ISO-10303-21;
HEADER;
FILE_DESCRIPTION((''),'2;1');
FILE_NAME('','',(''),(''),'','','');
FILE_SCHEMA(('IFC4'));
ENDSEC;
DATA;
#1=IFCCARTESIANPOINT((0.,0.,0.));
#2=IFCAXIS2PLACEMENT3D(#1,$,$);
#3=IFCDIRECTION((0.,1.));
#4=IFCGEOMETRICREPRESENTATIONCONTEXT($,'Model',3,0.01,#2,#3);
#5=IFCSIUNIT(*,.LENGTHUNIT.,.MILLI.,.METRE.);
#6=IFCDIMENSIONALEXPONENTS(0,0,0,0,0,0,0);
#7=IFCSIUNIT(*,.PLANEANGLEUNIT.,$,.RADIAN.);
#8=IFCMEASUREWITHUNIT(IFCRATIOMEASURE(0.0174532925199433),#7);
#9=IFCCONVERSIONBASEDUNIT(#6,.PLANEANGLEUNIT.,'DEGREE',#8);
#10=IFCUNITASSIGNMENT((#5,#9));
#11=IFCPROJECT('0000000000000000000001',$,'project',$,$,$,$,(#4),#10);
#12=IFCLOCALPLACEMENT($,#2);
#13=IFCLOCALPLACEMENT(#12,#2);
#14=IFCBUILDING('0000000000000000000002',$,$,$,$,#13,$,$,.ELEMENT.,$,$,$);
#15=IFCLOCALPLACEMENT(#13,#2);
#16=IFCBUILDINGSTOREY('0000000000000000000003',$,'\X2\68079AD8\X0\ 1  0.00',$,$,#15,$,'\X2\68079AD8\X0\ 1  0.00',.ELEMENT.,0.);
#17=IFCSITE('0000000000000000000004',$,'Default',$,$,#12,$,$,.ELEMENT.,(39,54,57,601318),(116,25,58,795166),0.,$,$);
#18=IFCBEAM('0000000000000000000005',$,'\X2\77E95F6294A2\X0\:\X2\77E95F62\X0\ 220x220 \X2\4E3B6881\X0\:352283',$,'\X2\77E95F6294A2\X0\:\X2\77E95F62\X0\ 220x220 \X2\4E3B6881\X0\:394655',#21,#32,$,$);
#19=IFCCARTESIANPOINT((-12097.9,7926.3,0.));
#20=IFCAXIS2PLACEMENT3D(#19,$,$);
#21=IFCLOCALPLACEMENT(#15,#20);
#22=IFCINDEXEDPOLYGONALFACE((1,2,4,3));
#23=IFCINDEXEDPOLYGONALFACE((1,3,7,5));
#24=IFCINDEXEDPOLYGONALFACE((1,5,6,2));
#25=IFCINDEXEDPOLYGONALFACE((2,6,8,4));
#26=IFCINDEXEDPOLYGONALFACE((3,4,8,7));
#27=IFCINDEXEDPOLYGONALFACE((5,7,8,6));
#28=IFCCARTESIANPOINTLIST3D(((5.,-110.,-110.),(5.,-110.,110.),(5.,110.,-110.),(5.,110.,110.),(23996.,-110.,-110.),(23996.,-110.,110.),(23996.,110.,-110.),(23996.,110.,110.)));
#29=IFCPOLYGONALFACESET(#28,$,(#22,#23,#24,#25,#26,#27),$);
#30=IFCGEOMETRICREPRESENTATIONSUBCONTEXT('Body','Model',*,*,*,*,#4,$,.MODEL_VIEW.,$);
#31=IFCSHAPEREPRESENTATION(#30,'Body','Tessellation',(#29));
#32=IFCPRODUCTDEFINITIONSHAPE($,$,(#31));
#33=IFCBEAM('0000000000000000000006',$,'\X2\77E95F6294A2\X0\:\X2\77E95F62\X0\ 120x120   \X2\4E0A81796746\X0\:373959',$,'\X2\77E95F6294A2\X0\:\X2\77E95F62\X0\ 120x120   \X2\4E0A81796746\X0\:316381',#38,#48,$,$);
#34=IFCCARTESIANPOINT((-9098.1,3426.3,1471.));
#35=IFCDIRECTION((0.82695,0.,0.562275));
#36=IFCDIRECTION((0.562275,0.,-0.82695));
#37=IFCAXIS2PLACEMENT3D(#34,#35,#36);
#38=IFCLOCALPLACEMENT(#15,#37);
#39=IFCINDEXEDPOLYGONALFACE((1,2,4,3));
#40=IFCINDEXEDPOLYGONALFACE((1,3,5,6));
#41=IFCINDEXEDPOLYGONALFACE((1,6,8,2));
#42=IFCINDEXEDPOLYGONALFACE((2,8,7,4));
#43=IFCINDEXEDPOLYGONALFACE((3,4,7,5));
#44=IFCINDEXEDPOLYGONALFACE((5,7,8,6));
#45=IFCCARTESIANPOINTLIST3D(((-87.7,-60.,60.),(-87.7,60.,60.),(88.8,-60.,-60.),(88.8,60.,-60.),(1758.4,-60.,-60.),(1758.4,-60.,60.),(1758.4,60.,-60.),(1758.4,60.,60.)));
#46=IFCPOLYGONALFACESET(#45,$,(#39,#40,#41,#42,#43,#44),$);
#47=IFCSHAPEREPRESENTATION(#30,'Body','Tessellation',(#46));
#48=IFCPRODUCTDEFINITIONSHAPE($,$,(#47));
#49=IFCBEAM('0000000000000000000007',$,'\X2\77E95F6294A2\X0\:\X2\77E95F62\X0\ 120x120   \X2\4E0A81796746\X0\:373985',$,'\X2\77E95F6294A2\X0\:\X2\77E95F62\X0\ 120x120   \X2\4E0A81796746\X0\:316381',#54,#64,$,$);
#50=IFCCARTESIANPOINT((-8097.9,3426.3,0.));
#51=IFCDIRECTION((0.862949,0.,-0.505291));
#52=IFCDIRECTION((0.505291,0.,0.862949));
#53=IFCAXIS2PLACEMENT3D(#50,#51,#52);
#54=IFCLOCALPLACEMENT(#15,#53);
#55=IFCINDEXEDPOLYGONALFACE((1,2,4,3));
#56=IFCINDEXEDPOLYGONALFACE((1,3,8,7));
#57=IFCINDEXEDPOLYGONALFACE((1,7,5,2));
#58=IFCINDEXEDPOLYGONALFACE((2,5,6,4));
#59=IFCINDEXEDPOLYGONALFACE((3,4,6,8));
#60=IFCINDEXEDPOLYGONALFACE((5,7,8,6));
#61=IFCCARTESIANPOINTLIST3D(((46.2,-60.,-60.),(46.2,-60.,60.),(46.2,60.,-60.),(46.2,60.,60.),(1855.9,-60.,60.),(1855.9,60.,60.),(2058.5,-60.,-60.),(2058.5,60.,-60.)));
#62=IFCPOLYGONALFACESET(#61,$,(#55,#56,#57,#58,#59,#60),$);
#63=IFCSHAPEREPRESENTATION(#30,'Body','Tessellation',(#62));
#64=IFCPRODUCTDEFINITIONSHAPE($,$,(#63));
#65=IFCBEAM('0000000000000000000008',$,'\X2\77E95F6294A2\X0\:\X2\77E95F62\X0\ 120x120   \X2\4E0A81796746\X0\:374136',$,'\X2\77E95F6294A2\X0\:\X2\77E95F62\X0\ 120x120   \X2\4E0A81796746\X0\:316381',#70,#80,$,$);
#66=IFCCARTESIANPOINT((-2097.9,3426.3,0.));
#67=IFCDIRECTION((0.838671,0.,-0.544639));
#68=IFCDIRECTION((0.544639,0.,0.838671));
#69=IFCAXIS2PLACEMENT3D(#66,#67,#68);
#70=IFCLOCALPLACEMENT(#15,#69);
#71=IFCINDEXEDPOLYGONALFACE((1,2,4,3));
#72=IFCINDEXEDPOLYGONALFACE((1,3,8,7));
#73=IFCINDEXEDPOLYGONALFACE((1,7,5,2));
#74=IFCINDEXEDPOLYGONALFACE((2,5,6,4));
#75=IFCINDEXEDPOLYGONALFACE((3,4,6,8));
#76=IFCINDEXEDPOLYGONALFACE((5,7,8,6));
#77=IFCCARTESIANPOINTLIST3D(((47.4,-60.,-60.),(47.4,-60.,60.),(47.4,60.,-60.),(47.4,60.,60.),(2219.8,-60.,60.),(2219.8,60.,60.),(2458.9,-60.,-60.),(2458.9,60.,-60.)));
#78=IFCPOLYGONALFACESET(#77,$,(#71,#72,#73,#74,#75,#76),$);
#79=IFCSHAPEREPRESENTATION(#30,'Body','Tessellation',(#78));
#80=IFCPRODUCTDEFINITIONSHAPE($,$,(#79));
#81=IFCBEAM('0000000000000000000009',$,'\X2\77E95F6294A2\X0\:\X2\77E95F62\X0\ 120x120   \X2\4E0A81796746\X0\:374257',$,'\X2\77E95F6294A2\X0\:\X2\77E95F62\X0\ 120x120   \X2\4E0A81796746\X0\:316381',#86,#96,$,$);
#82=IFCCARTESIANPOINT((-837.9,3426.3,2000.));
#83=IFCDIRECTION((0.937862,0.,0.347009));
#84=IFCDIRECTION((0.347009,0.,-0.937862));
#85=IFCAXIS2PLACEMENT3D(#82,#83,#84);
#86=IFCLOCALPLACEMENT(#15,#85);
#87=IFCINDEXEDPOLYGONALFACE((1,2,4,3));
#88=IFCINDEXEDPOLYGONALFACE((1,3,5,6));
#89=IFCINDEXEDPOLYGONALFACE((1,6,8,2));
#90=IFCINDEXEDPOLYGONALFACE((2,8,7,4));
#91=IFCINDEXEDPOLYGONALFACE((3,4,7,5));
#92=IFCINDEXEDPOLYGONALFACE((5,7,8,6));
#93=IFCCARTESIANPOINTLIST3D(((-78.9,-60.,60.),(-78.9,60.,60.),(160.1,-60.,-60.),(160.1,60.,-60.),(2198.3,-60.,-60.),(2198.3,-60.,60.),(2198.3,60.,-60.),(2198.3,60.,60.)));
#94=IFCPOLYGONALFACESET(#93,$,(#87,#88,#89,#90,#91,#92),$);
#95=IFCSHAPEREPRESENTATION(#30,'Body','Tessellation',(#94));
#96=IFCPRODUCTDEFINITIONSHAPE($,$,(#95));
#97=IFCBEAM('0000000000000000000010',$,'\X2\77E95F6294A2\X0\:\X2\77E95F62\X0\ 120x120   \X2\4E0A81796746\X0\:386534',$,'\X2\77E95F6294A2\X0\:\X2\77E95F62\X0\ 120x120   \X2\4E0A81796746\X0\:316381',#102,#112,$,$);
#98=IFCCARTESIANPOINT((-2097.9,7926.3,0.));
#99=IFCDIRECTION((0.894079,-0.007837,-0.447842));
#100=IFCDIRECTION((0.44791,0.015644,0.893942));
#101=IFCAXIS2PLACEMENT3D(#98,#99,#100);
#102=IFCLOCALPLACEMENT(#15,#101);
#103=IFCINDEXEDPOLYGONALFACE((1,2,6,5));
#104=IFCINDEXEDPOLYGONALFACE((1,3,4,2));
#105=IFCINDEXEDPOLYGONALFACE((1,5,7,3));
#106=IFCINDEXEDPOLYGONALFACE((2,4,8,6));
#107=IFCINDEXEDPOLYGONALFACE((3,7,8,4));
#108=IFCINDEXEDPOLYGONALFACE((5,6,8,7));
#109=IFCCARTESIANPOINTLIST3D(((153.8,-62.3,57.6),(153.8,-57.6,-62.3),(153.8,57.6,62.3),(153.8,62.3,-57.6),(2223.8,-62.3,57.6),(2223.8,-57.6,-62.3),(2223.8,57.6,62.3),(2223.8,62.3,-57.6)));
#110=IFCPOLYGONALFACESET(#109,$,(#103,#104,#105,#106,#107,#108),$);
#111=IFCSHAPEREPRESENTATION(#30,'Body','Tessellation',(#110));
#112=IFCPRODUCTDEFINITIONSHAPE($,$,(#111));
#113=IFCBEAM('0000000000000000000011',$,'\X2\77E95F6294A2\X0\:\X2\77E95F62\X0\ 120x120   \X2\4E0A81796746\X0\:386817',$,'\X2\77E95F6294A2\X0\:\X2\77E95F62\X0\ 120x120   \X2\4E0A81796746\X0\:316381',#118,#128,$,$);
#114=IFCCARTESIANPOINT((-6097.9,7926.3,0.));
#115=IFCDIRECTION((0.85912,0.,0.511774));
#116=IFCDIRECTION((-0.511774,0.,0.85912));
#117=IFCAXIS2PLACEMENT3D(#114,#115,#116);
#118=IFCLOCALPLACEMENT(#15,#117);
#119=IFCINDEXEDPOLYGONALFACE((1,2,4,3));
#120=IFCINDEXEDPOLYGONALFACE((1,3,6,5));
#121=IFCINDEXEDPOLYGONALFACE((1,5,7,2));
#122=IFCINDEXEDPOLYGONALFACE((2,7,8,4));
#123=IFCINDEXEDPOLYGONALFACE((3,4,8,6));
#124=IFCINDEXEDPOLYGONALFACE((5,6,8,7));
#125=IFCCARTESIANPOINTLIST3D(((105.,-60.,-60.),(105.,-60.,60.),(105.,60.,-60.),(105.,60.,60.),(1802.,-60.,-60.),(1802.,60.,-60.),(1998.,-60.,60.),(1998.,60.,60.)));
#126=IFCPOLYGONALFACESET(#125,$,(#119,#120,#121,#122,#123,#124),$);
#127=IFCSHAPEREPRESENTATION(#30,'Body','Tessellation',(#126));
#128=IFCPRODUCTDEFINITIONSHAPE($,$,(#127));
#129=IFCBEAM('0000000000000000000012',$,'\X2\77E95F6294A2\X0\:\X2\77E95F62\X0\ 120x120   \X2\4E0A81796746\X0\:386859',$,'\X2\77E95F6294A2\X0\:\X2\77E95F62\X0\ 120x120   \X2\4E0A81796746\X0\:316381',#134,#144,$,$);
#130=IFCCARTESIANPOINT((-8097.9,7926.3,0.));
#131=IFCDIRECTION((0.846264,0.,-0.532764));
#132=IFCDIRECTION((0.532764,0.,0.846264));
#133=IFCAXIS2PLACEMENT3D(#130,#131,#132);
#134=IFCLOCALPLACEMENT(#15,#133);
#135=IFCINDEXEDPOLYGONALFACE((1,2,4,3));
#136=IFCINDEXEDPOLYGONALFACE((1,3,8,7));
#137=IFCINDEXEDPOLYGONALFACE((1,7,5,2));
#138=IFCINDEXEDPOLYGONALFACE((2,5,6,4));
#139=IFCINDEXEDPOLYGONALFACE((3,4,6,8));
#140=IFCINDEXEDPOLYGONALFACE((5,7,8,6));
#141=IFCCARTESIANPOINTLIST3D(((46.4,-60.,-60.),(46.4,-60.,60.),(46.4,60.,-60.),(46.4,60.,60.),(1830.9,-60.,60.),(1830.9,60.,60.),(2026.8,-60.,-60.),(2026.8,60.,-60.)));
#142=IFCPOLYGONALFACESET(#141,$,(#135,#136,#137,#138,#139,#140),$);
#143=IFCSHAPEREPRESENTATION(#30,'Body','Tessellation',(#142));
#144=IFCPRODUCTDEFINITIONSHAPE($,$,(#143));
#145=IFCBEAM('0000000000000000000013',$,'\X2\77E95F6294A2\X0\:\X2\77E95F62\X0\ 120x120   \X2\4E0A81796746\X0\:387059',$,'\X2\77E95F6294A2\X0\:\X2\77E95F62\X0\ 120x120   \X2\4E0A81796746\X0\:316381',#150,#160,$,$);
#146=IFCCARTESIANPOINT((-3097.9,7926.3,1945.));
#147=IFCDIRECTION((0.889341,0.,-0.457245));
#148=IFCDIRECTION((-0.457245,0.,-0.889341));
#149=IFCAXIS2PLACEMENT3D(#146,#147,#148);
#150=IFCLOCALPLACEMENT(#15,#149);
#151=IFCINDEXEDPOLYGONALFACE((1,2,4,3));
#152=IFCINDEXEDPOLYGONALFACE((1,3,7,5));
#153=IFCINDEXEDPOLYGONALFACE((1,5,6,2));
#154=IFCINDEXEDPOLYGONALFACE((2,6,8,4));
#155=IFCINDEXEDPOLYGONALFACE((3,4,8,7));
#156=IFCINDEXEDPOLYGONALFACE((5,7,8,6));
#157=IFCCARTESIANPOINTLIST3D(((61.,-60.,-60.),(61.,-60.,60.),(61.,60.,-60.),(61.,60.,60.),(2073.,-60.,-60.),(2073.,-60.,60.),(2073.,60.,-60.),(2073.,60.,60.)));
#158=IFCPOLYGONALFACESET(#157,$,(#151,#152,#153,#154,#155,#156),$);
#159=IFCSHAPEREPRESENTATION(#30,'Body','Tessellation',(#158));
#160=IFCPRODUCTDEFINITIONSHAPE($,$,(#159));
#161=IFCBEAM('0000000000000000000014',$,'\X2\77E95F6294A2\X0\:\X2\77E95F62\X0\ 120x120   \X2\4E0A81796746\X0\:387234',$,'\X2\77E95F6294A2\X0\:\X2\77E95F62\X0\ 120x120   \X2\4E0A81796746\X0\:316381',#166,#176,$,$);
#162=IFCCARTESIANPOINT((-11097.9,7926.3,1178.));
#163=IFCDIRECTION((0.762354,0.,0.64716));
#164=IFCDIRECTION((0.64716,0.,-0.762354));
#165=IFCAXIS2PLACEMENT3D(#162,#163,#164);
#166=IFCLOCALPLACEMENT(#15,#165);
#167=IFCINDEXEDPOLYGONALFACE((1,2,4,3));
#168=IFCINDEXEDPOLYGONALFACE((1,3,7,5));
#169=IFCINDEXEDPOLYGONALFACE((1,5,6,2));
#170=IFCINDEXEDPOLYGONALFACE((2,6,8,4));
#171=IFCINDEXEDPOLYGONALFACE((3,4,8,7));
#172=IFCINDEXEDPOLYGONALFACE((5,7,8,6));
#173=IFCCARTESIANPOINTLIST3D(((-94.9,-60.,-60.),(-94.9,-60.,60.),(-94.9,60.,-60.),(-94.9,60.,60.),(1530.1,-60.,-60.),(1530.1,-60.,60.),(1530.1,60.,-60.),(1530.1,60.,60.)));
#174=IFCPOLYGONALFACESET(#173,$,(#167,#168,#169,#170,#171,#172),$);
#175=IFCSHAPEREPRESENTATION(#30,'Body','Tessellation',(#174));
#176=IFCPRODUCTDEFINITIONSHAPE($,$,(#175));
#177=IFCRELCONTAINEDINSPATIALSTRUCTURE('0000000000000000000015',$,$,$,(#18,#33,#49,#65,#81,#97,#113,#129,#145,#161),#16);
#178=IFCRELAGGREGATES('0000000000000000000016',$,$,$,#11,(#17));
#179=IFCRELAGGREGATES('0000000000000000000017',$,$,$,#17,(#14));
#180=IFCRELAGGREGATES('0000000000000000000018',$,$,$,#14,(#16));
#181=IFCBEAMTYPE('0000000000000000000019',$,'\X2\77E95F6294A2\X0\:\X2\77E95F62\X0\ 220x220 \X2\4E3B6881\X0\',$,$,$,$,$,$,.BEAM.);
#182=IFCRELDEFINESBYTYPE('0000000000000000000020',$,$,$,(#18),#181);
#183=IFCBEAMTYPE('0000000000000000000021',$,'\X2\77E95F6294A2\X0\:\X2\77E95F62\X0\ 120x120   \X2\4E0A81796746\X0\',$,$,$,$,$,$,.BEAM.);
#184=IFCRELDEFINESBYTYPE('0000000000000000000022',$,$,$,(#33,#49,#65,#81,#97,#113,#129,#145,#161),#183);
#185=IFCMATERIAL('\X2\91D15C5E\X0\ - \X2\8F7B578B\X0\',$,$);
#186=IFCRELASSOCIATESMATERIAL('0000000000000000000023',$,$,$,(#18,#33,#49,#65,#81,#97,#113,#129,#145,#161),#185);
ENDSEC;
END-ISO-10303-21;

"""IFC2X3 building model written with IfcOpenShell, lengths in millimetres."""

from ifc_helpers import new_model, entity, si_unit, converted_unit, direction, frame, frame_2d, origin, place, context, subcontext, project, spatial, rectangle, extrude, clip, halfspace, material, type_object, element, save


model = new_model("IFC2X3")

# Units and contexts
model_context = context("Model", 3, precision=0.01, world=origin(), true_north=direction((0.0, 1.0)))
body_context = subcontext(model_context, "Body", "Model", "MODEL_VIEW")
ifc_project = project(units=[si_unit("LENGTHUNIT", "METRE", prefix="MILLI"), converted_unit("PLANEANGLEUNIT", "DEGREE", entity("IfcRatioMeasure", 0.0174532925199433), si_unit("PLANEANGLEUNIT", "RADIAN"), dimensions=[0, 0, 0, 0, 0, 0, 0])], contexts=[model_context])

# Site, building, storey
site_placement = place(None, origin())
site = spatial("IfcSite", under=ifc_project, at=site_placement, Name="Default", CompositionType="ELEMENT", RefLatitude=(39, 54, 57, 601318), RefLongitude=(116, 25, 58, 795166), RefElevation=0.0)
building_placement = place(site_placement, origin())
building = spatial("IfcBuilding", under=site, at=building_placement, CompositionType="ELEMENT")
storey_placement = place(building_placement, origin())
storey = spatial("IfcBuildingStorey", under=building, at=storey_placement, Name="标高 1  0.00", LongName="标高 1  0.00", CompositionType="ELEMENT", Elevation=0.0)

# Shared definitions
ifc_material_1 = material(Name="金属 - 轻型")

# Beams
beam_type_1 = type_object("IfcBeamType", Name="矩形钢:矩形 220x220 主梁", PredefinedType="BEAM")
beam_1_placement = place(storey_placement, frame((-12097.9, 7926.3, 0.0)))
element("IfcBeam", 1, at=beam_1_placement, inside=storey, type_object=beam_type_1, material=ifc_material_1, Name="矩形钢:矩形 220x220 主梁:352283", ObjectType="矩形钢:矩形 220x220 主梁:394655", context=body_context, shape_type="SweptSolid", body=[
    extrude(rectangle(XDim=220.0, YDim=220.0, at=frame_2d((0.0, 0.0), x_axis=(1.0, 0.0))), frame((5.0, 0.0, 0.0), z_axis=(1.0, 0.0, 0.0), x_axis=(0.0, 0.0, -1.0)), (0.0, 0.0, 1.0), 23991.0),
])
beam_type_2 = type_object("IfcBeamType", Name="矩形钢:矩形 120x120   上腹杆", PredefinedType="BEAM")
beam_2_placement = place(storey_placement, frame((-9098.1, 3426.3, 1471.0), z_axis=(0.82695, 0.0, 0.562275), x_axis=(0.562275, 0.0, -0.82695)))
element("IfcBeam", 2, at=beam_2_placement, inside=storey, type_object=beam_type_2, material=ifc_material_1, Name="矩形钢:矩形 120x120   上腹杆:373959", ObjectType="矩形钢:矩形 120x120   上腹杆:316381", context=body_context, shape_type="Clipping", body=[
    clip(extrude(rectangle(XDim=120.0, YDim=120.0, at=frame_2d((0.0, 0.0), x_axis=(1.0, 0.0))), frame((-87.7, 0.0, 0.0), z_axis=(1.0, 0.0, 0.0), x_axis=(0.0, 0.0, -1.0)), (0.0, 0.0, 1.0), 1846.1), halfspace(frame((-87.7, 0.0, 60.0), z_axis=(-0.562323, 0.0, -0.826918), x_axis=(0.0, 1.0, 0.0)), False)),
])
beam_3_placement = place(storey_placement, frame((-8097.9, 3426.3, 0.0), z_axis=(0.862949, 0.0, -0.505291), x_axis=(0.505291, 0.0, 0.862949)))
element("IfcBeam", 3, at=beam_3_placement, inside=storey, type_object=beam_type_2, material=ifc_material_1, Name="矩形钢:矩形 120x120   上腹杆:373985", ObjectType="矩形钢:矩形 120x120   上腹杆:316381", context=body_context, shape_type="Clipping", body=[
    clip(extrude(rectangle(XDim=120.0, YDim=120.0, at=frame_2d((0.0, 0.0), x_axis=(1.0, 0.0))), frame((46.2, 0.0, 0.0), z_axis=(1.0, 0.0, 0.0), x_axis=(0.0, 0.0, -1.0)), (0.0, 0.0, 1.0), 2012.3), halfspace(frame((2058.5, 0.0, -60.0), z_axis=(0.509462, 0.0, 0.860493), x_axis=(-0.860493, 0.0, 0.509462)), False)),
])
beam_4_placement = place(storey_placement, frame((-2097.9, 3426.3, 0.0), z_axis=(0.838671, 0.0, -0.544639), x_axis=(0.544639, 0.0, 0.838671)))
element("IfcBeam", 4, at=beam_4_placement, inside=storey, type_object=beam_type_2, material=ifc_material_1, Name="矩形钢:矩形 120x120   上腹杆:374136", ObjectType="矩形钢:矩形 120x120   上腹杆:316381", context=body_context, shape_type="Clipping", body=[
    clip(extrude(rectangle(XDim=120.0, YDim=120.0, at=frame_2d((0.0, 0.0), x_axis=(1.0, 0.0))), frame((47.4, 0.0, 0.0), z_axis=(1.0, 0.0, 0.0), x_axis=(0.0, 0.0, -1.0)), (0.0, 0.0, 1.0), 2411.5), halfspace(frame((2458.9, 0.0, -60.0), z_axis=(0.448574, 0.0, 0.893746), x_axis=(0.893746, 0.0, -0.448574)), False)),
])
beam_5_placement = place(storey_placement, frame((-837.9, 3426.3, 2000.0), z_axis=(0.937862, 0.0, 0.347009), x_axis=(0.347009, 0.0, -0.937862)))
element("IfcBeam", 5, at=beam_5_placement, inside=storey, type_object=beam_type_2, material=ifc_material_1, Name="矩形钢:矩形 120x120   上腹杆:374257", ObjectType="矩形钢:矩形 120x120   上腹杆:316381", context=body_context, shape_type="Clipping", body=[
    clip(extrude(rectangle(XDim=120.0, YDim=120.0, at=frame_2d((0.0, 0.0), x_axis=(1.0, 0.0))), frame((-78.9, 0.0, 0.0), z_axis=(1.0, 0.0, 0.0), x_axis=(0.0, 0.0, -1.0)), (0.0, 0.0, 1.0), 2277.2), halfspace(frame((-78.9, 0.0, 60.0), z_axis=(-0.448574, 0.0, -0.893746), x_axis=(-0.893746, 0.0, 0.448574)), False)),
])
beam_6_placement = place(storey_placement, frame((-2097.9, 7926.3, 0.0), z_axis=(0.894079, -0.007837, -0.447842), x_axis=(0.44791, 0.015644, 0.893942)))
element("IfcBeam", 6, at=beam_6_placement, inside=storey, type_object=beam_type_2, material=ifc_material_1, Name="矩形钢:矩形 120x120   上腹杆:386534", ObjectType="矩形钢:矩形 120x120   上腹杆:316381", context=body_context, shape_type="SweptSolid", body=[
    extrude(rectangle(XDim=120.0, YDim=120.0, at=frame_2d((0.0, 0.0), x_axis=(1.0, 0.0))), frame((153.8, 0.0, 0.0), z_axis=(1.0, 0.0, 0.0), x_axis=(0.0, -0.03904, 0.999238)), (0.0, 0.0, 1.0), 2070.0),
])
beam_7_placement = place(storey_placement, frame((-6097.9, 7926.3, 0.0), z_axis=(0.85912, 0.0, 0.511774), x_axis=(-0.511774, 0.0, 0.85912)))
element("IfcBeam", 7, at=beam_7_placement, inside=storey, type_object=beam_type_2, material=ifc_material_1, Name="矩形钢:矩形 120x120   上腹杆:386817", ObjectType="矩形钢:矩形 120x120   上腹杆:316381", context=body_context, shape_type="Clipping", body=[
    clip(extrude(rectangle(XDim=120.0, YDim=120.0, at=frame_2d((0.0, 0.0), x_axis=(1.0, 0.0))), frame((105.0, 0.0, 0.0), z_axis=(1.0, 0.0, 0.0), x_axis=(0.0, 0.0, -1.0)), (0.0, 0.0, 1.0), 1893.0), halfspace(frame((1802.0, 0.0, -60.0), z_axis=(0.522309, 0.0, -0.852757), x_axis=(0.852757, 0.0, 0.522309)), False)),
])
beam_8_placement = place(storey_placement, frame((-8097.9, 7926.3, 0.0), z_axis=(0.846264, 0.0, -0.532764), x_axis=(0.532764, 0.0, 0.846264)))
element("IfcBeam", 8, at=beam_8_placement, inside=storey, type_object=beam_type_2, material=ifc_material_1, Name="矩形钢:矩形 120x120   上腹杆:386859", ObjectType="矩形钢:矩形 120x120   上腹杆:316381", context=body_context, shape_type="Clipping", body=[
    clip(extrude(rectangle(XDim=120.0, YDim=120.0, at=frame_2d((0.0, 0.0), x_axis=(1.0, 0.0))), frame((46.4, 0.0, 0.0), z_axis=(1.0, 0.0, 0.0), x_axis=(0.0, 0.0, -1.0)), (0.0, 0.0, 1.0), 1980.4), halfspace(frame((1830.9, 0.0, 60.0), z_axis=(0.522309, 0.0, 0.852757), x_axis=(0.852757, 0.0, -0.522309)), False)),
])
beam_9_placement = place(storey_placement, frame((-3097.9, 7926.3, 1945.0), z_axis=(0.889341, 0.0, -0.457245), x_axis=(-0.457245, 0.0, -0.889341)))
element("IfcBeam", 9, at=beam_9_placement, inside=storey, type_object=beam_type_2, material=ifc_material_1, Name="矩形钢:矩形 120x120   上腹杆:387059", ObjectType="矩形钢:矩形 120x120   上腹杆:316381", context=body_context, shape_type="SweptSolid", body=[
    extrude(rectangle(XDim=120.0, YDim=120.0, at=frame_2d((0.0, 0.0), x_axis=(1.0, 0.0))), frame((61.0, 0.0, 0.0), z_axis=(1.0, 0.0, 0.0), x_axis=(0.0, 0.0, -1.0)), (0.0, 0.0, 1.0), 2012.0),
])
beam_10_placement = place(storey_placement, frame((-11097.9, 7926.3, 1178.0), z_axis=(0.762354, 0.0, 0.64716), x_axis=(0.64716, 0.0, -0.762354)))
element("IfcBeam", 10, at=beam_10_placement, inside=storey, type_object=beam_type_2, material=ifc_material_1, Name="矩形钢:矩形 120x120   上腹杆:387234", ObjectType="矩形钢:矩形 120x120   上腹杆:316381", context=body_context, shape_type="SweptSolid", body=[
    extrude(rectangle(XDim=120.0, YDim=120.0, at=frame_2d((0.0, 0.0), x_axis=(1.0, 0.0))), frame((-94.9, 0.0, 0.0), z_axis=(1.0, 0.0, 0.0), x_axis=(0.0, 0.0, -1.0)), (0.0, 0.0, 1.0), 1625.0),
])

save(model, "model.ifc")
